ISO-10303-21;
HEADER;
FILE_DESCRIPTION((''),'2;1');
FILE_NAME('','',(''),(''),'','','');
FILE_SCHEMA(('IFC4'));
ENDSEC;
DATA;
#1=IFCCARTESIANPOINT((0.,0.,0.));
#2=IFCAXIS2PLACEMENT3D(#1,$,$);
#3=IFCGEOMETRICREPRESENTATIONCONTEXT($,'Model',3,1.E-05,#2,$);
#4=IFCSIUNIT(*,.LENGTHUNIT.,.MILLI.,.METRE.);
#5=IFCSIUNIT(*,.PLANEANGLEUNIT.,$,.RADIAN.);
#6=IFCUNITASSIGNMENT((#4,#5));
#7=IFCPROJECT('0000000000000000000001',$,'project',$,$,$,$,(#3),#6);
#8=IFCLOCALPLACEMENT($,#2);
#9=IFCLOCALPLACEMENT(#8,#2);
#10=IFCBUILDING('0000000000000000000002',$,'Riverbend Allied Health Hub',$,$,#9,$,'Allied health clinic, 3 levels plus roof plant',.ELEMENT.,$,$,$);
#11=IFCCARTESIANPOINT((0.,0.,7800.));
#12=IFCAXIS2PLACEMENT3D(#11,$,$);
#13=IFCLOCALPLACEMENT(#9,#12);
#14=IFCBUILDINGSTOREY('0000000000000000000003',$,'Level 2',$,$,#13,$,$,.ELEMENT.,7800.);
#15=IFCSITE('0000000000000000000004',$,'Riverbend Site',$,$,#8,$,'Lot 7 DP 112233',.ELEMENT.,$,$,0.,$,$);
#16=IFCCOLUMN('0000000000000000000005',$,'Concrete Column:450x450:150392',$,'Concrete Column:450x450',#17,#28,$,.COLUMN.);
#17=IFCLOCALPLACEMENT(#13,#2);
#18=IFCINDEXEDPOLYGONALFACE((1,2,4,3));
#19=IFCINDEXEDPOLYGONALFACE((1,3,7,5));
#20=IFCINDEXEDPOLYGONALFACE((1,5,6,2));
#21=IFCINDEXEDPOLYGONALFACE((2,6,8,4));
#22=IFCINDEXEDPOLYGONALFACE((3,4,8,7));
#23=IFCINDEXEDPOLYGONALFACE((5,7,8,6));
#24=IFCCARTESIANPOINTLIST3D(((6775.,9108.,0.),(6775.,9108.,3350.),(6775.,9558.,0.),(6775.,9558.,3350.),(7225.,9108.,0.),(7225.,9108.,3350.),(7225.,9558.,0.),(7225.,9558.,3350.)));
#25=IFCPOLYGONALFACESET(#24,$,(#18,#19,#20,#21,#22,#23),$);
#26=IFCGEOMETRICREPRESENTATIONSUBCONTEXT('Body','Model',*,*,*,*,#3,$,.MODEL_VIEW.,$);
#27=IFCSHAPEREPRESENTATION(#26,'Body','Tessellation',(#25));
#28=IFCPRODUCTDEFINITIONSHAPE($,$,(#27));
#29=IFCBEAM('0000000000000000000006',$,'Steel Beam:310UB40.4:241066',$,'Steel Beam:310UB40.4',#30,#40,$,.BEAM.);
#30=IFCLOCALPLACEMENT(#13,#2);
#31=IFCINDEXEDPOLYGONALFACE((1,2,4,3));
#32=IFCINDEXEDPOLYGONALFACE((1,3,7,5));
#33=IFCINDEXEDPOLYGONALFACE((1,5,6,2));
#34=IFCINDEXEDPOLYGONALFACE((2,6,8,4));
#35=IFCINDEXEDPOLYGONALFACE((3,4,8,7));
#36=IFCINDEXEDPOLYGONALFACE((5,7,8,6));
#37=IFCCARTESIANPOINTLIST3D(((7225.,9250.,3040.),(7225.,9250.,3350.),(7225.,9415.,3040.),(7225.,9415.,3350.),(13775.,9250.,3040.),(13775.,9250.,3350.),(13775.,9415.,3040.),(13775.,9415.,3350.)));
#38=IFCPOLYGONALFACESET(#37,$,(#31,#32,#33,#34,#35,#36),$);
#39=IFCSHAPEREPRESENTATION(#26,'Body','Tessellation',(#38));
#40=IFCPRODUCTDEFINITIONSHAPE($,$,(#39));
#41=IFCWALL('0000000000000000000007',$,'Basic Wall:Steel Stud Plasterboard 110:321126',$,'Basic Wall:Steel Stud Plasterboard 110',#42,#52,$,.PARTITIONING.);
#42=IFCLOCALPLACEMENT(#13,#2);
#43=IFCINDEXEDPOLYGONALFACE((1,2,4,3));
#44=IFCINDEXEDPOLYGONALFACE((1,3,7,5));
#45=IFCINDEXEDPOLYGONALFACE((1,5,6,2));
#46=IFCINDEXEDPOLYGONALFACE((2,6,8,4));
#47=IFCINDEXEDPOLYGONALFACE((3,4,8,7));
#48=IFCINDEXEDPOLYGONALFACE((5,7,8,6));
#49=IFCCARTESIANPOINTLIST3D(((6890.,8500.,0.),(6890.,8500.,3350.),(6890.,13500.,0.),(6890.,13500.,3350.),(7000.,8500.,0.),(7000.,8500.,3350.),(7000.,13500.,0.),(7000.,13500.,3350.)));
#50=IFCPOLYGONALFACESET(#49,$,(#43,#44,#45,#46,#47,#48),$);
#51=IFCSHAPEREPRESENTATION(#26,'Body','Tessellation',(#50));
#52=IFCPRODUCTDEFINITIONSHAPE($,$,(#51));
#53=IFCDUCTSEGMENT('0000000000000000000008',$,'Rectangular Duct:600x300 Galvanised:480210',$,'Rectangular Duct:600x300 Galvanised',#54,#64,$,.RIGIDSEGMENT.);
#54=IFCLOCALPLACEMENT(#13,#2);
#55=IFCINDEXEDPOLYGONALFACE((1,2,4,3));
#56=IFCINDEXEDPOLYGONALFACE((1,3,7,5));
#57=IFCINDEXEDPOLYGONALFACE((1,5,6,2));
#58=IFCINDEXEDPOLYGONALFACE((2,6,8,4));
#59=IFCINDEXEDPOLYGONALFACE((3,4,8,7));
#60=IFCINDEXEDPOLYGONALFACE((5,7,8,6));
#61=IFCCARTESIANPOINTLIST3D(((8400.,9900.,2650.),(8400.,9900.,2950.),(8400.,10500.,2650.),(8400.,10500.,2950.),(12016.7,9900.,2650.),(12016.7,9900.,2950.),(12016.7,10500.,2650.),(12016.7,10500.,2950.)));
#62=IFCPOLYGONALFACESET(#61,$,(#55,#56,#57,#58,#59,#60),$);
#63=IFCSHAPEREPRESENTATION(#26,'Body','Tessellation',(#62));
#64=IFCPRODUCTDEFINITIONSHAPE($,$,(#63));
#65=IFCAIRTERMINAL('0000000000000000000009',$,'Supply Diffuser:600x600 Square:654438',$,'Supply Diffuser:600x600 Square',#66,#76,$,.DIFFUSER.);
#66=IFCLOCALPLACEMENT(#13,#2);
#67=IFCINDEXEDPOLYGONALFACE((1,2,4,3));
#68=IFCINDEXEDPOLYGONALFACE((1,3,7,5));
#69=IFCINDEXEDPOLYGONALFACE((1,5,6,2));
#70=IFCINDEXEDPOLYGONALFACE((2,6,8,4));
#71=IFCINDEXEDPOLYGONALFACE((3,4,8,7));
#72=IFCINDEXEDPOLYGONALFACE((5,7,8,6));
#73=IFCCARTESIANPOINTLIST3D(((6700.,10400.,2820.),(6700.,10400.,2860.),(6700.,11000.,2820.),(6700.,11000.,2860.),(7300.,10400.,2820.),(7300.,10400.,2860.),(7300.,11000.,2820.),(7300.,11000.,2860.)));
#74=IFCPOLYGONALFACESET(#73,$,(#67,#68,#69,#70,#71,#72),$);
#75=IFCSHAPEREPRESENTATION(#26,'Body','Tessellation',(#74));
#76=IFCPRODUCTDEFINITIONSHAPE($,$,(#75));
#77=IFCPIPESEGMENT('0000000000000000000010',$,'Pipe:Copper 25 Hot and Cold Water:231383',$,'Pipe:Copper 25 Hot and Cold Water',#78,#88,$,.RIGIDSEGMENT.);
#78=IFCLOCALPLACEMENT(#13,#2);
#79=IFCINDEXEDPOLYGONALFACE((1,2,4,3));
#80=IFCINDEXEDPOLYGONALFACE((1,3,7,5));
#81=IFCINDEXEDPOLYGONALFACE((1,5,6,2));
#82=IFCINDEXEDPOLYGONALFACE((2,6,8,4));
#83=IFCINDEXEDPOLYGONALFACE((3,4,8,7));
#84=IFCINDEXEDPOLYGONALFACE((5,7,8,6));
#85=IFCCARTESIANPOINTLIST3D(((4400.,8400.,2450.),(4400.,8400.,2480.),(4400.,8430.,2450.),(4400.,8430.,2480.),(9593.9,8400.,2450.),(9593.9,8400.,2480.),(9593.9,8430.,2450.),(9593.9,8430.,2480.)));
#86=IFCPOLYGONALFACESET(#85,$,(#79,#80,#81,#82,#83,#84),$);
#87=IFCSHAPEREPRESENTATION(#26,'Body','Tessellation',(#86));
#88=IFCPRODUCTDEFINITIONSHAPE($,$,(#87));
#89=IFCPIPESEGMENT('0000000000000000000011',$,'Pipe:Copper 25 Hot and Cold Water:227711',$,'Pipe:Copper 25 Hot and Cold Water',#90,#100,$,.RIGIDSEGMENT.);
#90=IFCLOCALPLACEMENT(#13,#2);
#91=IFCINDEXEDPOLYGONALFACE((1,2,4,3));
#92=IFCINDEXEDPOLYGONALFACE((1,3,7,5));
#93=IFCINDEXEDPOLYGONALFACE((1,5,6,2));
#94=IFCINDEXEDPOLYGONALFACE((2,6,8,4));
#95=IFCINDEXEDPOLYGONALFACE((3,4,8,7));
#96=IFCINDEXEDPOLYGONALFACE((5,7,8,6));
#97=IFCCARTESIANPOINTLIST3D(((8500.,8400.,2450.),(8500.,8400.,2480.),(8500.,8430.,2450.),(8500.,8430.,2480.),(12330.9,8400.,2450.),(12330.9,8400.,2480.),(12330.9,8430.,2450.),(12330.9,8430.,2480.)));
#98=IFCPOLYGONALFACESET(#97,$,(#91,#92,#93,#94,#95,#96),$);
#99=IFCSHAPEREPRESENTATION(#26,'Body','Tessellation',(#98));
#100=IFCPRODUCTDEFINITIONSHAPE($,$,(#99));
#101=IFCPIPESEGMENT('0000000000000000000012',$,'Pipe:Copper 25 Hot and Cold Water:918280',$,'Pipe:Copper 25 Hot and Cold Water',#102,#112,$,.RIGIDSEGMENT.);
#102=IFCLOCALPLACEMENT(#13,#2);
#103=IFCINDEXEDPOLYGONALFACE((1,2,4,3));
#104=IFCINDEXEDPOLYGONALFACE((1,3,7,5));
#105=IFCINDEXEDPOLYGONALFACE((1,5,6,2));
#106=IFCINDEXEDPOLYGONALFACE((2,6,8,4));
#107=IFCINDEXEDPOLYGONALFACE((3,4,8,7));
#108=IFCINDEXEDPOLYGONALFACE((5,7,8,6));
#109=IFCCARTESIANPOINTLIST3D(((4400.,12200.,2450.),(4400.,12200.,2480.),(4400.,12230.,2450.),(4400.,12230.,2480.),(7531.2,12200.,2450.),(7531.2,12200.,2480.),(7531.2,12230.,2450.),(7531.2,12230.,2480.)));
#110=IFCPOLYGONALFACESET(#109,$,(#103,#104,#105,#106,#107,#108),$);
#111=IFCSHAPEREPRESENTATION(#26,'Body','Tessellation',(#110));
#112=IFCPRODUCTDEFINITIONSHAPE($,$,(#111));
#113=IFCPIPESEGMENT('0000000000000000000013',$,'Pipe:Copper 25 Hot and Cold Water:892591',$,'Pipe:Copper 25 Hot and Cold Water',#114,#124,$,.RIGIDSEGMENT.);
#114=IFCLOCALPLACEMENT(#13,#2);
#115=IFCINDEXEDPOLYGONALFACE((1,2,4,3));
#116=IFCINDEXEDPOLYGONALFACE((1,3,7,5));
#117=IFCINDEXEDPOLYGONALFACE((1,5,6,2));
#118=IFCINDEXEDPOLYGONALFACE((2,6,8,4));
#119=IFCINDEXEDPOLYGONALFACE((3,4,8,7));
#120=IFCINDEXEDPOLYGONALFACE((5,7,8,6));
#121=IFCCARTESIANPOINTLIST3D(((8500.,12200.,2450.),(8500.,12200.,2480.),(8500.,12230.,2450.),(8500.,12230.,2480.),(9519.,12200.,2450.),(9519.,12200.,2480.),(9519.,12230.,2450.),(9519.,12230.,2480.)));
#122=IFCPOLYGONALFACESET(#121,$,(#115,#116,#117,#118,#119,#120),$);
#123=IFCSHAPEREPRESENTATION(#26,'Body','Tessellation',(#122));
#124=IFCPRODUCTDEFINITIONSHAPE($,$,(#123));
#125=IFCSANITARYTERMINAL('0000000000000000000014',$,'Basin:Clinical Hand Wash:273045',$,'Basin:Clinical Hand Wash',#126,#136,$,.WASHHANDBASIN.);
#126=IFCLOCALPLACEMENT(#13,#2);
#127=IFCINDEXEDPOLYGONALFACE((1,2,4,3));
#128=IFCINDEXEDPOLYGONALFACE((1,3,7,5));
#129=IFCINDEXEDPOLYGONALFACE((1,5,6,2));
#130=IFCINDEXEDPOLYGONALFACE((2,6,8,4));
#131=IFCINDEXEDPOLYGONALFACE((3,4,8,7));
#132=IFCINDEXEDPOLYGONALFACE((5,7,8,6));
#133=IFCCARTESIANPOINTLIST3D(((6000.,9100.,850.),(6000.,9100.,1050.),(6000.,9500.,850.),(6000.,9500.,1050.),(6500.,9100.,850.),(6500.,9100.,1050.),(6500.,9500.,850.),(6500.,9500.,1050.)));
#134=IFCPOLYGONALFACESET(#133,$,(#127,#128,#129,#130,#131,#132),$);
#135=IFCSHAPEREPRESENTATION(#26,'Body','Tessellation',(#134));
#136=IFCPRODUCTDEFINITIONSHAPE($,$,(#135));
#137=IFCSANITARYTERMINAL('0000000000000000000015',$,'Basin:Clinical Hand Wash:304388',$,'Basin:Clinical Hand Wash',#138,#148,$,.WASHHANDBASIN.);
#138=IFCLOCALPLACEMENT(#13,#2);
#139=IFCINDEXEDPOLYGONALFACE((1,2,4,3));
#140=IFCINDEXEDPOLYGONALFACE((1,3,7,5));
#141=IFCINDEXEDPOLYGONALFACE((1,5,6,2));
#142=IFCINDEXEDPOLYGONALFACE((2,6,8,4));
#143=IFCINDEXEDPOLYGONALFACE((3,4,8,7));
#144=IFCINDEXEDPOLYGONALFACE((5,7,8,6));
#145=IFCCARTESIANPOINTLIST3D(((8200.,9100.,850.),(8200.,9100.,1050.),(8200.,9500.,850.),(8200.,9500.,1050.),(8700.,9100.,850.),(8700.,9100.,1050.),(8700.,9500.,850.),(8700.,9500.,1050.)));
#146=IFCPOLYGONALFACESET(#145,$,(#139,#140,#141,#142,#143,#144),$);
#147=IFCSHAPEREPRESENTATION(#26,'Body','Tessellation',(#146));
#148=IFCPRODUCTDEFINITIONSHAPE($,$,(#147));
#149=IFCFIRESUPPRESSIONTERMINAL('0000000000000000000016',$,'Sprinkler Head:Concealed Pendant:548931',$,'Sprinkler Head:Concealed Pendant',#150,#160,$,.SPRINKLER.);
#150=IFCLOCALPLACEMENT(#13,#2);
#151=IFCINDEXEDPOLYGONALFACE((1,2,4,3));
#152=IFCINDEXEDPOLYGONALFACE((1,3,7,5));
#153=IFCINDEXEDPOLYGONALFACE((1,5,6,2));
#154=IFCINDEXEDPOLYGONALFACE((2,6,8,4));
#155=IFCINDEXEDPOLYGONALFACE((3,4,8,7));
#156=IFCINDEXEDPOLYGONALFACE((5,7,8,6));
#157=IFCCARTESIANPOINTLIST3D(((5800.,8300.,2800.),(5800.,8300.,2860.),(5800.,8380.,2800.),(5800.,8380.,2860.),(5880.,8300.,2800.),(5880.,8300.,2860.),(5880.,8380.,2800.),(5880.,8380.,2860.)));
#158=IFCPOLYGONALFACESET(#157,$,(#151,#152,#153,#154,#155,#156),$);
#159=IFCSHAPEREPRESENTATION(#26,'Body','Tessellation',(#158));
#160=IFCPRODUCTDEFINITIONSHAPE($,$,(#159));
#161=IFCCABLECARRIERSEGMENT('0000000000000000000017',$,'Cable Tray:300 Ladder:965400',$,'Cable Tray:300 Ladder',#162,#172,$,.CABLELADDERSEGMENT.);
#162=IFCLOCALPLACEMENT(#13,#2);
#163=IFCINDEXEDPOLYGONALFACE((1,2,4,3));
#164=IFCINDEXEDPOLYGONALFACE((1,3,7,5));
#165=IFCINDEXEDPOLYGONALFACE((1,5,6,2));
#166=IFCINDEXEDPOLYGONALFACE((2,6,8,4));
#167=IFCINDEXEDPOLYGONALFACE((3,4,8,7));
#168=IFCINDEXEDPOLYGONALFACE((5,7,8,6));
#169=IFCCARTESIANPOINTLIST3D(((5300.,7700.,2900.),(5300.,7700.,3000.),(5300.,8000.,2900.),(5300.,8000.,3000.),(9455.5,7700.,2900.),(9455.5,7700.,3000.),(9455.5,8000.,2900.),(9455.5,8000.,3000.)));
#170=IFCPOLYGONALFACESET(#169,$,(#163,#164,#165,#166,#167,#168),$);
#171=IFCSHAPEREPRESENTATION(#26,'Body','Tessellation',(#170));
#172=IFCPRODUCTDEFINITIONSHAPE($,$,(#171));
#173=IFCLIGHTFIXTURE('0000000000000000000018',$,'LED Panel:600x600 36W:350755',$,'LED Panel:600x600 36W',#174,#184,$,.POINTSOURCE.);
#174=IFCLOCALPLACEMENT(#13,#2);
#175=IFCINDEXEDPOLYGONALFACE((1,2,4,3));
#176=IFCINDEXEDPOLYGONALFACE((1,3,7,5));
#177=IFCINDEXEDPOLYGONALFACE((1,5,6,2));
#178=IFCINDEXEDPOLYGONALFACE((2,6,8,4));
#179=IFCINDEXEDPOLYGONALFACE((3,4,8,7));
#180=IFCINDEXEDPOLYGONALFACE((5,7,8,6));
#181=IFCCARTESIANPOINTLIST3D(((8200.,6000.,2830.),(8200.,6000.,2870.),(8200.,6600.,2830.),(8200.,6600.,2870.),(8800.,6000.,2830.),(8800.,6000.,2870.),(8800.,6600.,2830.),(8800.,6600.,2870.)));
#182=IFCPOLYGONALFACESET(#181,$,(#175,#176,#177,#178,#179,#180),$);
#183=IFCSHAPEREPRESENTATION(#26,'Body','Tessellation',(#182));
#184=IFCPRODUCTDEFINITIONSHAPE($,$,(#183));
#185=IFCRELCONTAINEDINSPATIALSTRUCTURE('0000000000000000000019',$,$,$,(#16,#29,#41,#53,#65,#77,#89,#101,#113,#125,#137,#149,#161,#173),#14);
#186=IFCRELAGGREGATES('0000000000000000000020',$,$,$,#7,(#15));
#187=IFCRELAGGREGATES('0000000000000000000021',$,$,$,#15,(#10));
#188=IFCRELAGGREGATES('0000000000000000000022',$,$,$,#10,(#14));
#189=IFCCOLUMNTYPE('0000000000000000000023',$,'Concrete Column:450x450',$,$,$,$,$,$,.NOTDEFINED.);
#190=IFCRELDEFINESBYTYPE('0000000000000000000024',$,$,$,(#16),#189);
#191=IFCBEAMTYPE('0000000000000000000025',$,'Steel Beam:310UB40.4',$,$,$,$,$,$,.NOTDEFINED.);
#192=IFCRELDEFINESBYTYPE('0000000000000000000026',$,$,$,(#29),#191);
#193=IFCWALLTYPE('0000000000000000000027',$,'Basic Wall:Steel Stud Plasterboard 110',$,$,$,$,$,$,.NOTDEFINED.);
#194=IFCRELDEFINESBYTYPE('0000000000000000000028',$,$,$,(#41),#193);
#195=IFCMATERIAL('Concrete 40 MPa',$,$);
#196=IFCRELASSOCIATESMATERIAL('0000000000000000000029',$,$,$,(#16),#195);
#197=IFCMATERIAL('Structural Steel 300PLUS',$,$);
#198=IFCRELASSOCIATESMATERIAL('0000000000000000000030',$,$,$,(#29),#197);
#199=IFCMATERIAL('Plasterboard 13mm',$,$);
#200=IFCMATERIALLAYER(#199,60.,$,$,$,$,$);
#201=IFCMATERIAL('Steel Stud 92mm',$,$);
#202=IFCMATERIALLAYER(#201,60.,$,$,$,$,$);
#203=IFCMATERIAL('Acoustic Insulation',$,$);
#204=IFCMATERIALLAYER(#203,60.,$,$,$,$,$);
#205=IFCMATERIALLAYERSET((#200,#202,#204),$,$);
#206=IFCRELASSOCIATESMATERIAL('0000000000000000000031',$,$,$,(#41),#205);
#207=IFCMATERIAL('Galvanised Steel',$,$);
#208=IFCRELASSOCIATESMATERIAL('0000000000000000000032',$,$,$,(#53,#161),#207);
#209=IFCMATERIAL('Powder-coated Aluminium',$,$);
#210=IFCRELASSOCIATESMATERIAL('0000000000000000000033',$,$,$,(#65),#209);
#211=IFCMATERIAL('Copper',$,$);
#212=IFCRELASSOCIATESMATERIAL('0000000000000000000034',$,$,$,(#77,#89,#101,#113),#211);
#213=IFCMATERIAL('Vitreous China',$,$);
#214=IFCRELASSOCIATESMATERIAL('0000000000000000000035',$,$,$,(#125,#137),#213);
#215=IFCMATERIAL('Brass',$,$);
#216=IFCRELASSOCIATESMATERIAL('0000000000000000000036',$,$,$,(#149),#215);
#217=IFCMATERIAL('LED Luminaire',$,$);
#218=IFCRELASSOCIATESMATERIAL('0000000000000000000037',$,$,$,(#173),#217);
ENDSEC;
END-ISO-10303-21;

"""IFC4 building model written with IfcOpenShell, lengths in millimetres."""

from ifc_helpers import new_model, si_unit, frame, frame_2d, origin, place, context, subcontext, project, spatial, rectangle, extrude, material, layer, layer_set, layer_usage, type_object, element, save


model = new_model("IFC4")

# Units and contexts
model_context = context("Model", 3, precision=1e-05, world=origin())
body_context = subcontext(model_context, "Body", "Model", "MODEL_VIEW")
ifc_project = project(units=[si_unit("LENGTHUNIT", "METRE", prefix="MILLI"), si_unit("PLANEANGLEUNIT", "RADIAN")], contexts=[model_context])

# Site, building, storey
site_placement = place(None, origin())
site = spatial("IfcSite", under=ifc_project, at=site_placement, Name="Riverbend Site", LongName="Lot 7 DP 112233", CompositionType="ELEMENT", RefElevation=0.0)
building_placement = place(site_placement, origin())
building = spatial("IfcBuilding", under=site, at=building_placement, Name="Riverbend Allied Health Hub", LongName="Allied health clinic, 3 levels plus roof plant", CompositionType="ELEMENT")
storey_placement = place(building_placement, frame((0.0, 0.0, 7800.0)))
storey = spatial("IfcBuildingStorey", under=building, at=storey_placement, Name="Level 2", CompositionType="ELEMENT", Elevation=7800.0)

# Column
ifc_material_1 = material(Name="Concrete 40 MPa")
column_type = type_object("IfcColumnType", Name="Concrete Column:450x450", PredefinedType="NOTDEFINED")
column_placement = place(storey_placement, frame((6775.0, 9108.0, 0.0)))
element("IfcColumn", 1, at=column_placement, inside=storey, type_object=column_type, material=ifc_material_1, Name="Concrete Column:450x450:150392", ObjectType="Concrete Column:450x450", PredefinedType="COLUMN", context=body_context, shape_type="SweptSolid", body=[
    extrude(rectangle(XDim=450.0, YDim=450.0, at=frame_2d((225.0, 225.0))), origin(), (0.0, 0.0, 1.0), 3350.0),
])

# Beam
ifc_material_2 = material(Name="Structural Steel 300PLUS")
beam_type = type_object("IfcBeamType", Name="Steel Beam:310UB40.4", PredefinedType="NOTDEFINED")
beam_placement = place(storey_placement, frame((7225.0, 9250.0, 3040.0)))
element("IfcBeam", 2, at=beam_placement, inside=storey, type_object=beam_type, material=ifc_material_2, Name="Steel Beam:310UB40.4:241066", ObjectType="Steel Beam:310UB40.4", PredefinedType="BEAM", context=body_context, shape_type="SweptSolid", body=[
    extrude(rectangle(XDim=6550.0, YDim=165.0, at=frame_2d((3275.0, 82.5))), origin(), (0.0, 0.0, 1.0), 310.0),
])

# Wall
ifc_material_3 = material(Name="Plasterboard 13mm")
ifc_layer_1 = layer(ifc_material_3, 60.0)
ifc_material_4 = material(Name="Steel Stud 92mm")
ifc_layer_2 = layer(ifc_material_4, 60.0)
ifc_material_5 = material(Name="Acoustic Insulation")
ifc_layer_3 = layer(ifc_material_5, 60.0)
ifc_layer_set = layer_set([ifc_layer_1, ifc_layer_2, ifc_layer_3])
ifc_layer_usage = layer_usage(ifc_layer_set, "AXIS2", "POSITIVE", 0.0)
wall_type = type_object("IfcWallType", Name="Basic Wall:Steel Stud Plasterboard 110", PredefinedType="NOTDEFINED")
wall_placement = place(storey_placement, frame((7000.0, 8500.0, 0.0), z_axis=(0.0, 0.0, 1.0), x_axis=(0.0, 1.0, 0.0)))
element("IfcWall", 3, at=wall_placement, inside=storey, type_object=wall_type, material=ifc_layer_usage, Name="Basic Wall:Steel Stud Plasterboard 110:321126", ObjectType="Basic Wall:Steel Stud Plasterboard 110", PredefinedType="PARTITIONING", context=body_context, shape_type="SweptSolid", body=[
    extrude(rectangle(XDim=5000.0, YDim=110.0, at=frame_2d((2500.0, 55.0))), origin(), (0.0, 0.0, 1.0), 3350.0),
])

# Duct segment
ifc_material_6 = material(Name="Galvanised Steel")
duct_segment_placement = place(storey_placement, frame((8400.0, 9900.0, 2650.0)))
element("IfcDuctSegment", 4, at=duct_segment_placement, inside=storey, material=ifc_material_6, Name="Rectangular Duct:600x300 Galvanised:480210", ObjectType="Rectangular Duct:600x300 Galvanised", PredefinedType="RIGIDSEGMENT", context=body_context, shape_type="SweptSolid", body=[
    extrude(rectangle(XDim=3616.7, YDim=600.0, at=frame_2d((1808.4, 300.0))), origin(), (0.0, 0.0, 1.0), 300.0),
])

# Air terminal
ifc_material_7 = material(Name="Powder-coated Aluminium")
air_terminal_placement = place(storey_placement, frame((6700.0, 10400.0, 2820.0)))
element("IfcAirTerminal", 5, at=air_terminal_placement, inside=storey, material=ifc_material_7, Name="Supply Diffuser:600x600 Square:654438", ObjectType="Supply Diffuser:600x600 Square", PredefinedType="DIFFUSER", context=body_context, shape_type="SweptSolid", body=[
    extrude(rectangle(XDim=600.0, YDim=600.0, at=frame_2d((300.0, 300.0))), origin(), (0.0, 0.0, 1.0), 40.0),
])

# Pipe segments
ifc_material_8 = material(Name="Copper")
pipe_segment_1_placement = place(storey_placement, frame((4400.0, 8400.0, 2450.0)))
element("IfcPipeSegment", 6, at=pipe_segment_1_placement, inside=storey, material=ifc_material_8, Name="Pipe:Copper 25 Hot and Cold Water:231383", ObjectType="Pipe:Copper 25 Hot and Cold Water", PredefinedType="RIGIDSEGMENT", context=body_context, shape_type="SweptSolid", body=[
    extrude(rectangle(XDim=5193.9, YDim=30.0, at=frame_2d((2596.9, 15.0))), origin(), (0.0, 0.0, 1.0), 30.0),
])
pipe_segment_2_placement = place(storey_placement, frame((8500.0, 8400.0, 2450.0)))
element("IfcPipeSegment", 7, at=pipe_segment_2_placement, inside=storey, material=ifc_material_8, Name="Pipe:Copper 25 Hot and Cold Water:227711", ObjectType="Pipe:Copper 25 Hot and Cold Water", PredefinedType="RIGIDSEGMENT", context=body_context, shape_type="SweptSolid", body=[
    extrude(rectangle(XDim=3830.9, YDim=30.0, at=frame_2d((1915.5, 15.0))), origin(), (0.0, 0.0, 1.0), 30.0),
])
pipe_segment_3_placement = place(storey_placement, frame((4400.0, 12200.0, 2450.0)))
element("IfcPipeSegment", 8, at=pipe_segment_3_placement, inside=storey, material=ifc_material_8, Name="Pipe:Copper 25 Hot and Cold Water:918280", ObjectType="Pipe:Copper 25 Hot and Cold Water", PredefinedType="RIGIDSEGMENT", context=body_context, shape_type="SweptSolid", body=[
    extrude(rectangle(XDim=3131.2, YDim=30.0, at=frame_2d((1565.6, 15.0))), origin(), (0.0, 0.0, 1.0), 30.0),
])
pipe_segment_4_placement = place(storey_placement, frame((8500.0, 12200.0, 2450.0)))
element("IfcPipeSegment", 9, at=pipe_segment_4_placement, inside=storey, material=ifc_material_8, Name="Pipe:Copper 25 Hot and Cold Water:892591", ObjectType="Pipe:Copper 25 Hot and Cold Water", PredefinedType="RIGIDSEGMENT", context=body_context, shape_type="SweptSolid", body=[
    extrude(rectangle(XDim=1019.0, YDim=30.0, at=frame_2d((509.5, 15.0))), origin(), (0.0, 0.0, 1.0), 30.0),
])

# Sanitary terminals
ifc_material_9 = material(Name="Vitreous China")
for number, where, name in (
    (10, (6000.0, 9100.0, 850.0), "Basin:Clinical Hand Wash:273045"),
    (11, (8200.0, 9100.0, 850.0), "Basin:Clinical Hand Wash:304388"),
):
    element("IfcSanitaryTerminal", number, at=place(storey_placement, frame(where)), inside=storey, material=ifc_material_9, Name=name, ObjectType="Basin:Clinical Hand Wash", PredefinedType="WASHHANDBASIN", context=body_context, shape_type="SweptSolid", body=[
        extrude(rectangle(XDim=500.0, YDim=400.0, at=frame_2d((250.0, 200.0))), origin(), (0.0, 0.0, 1.0), 200.0),
    ])

# Fire suppression terminal
ifc_material_10 = material(Name="Brass")
fire_suppression_terminal_placement = place(storey_placement, frame((5800.0, 8300.0, 2800.0)))
element("IfcFireSuppressionTerminal", 12, at=fire_suppression_terminal_placement, inside=storey, material=ifc_material_10, Name="Sprinkler Head:Concealed Pendant:548931", ObjectType="Sprinkler Head:Concealed Pendant", PredefinedType="SPRINKLER", context=body_context, shape_type="SweptSolid", body=[
    extrude(rectangle(XDim=80.0, YDim=80.0, at=frame_2d((40.0, 40.0))), origin(), (0.0, 0.0, 1.0), 60.0),
])

# Cable carrier segment
cable_carrier_segment_placement = place(storey_placement, frame((5300.0, 7700.0, 2900.0)))
element("IfcCableCarrierSegment", 13, at=cable_carrier_segment_placement, inside=storey, material=ifc_material_6, Name="Cable Tray:300 Ladder:965400", ObjectType="Cable Tray:300 Ladder", PredefinedType="CABLELADDERSEGMENT", context=body_context, shape_type="SweptSolid", body=[
    extrude(rectangle(XDim=4155.5, YDim=300.0, at=frame_2d((2077.8, 150.0))), origin(), (0.0, 0.0, 1.0), 100.0),
])

# Light fixture
ifc_material_11 = material(Name="LED Luminaire")
for number, where, name in (
    (14, (8200.0, 6000.0, 2830.0), "LED Panel:600x600 36W:350755"),
):
    element("IfcLightFixture", number, at=place(storey_placement, frame(where)), inside=storey, material=ifc_material_11, Name=name, ObjectType="LED Panel:600x600 36W", PredefinedType="POINTSOURCE", context=body_context, shape_type="SweptSolid", body=[
        extrude(rectangle(XDim=600.0, YDim=600.0, at=frame_2d((300.0, 300.0))), origin(), (0.0, 0.0, 1.0), 40.0),
    ])

save(model, "model.ifc")
